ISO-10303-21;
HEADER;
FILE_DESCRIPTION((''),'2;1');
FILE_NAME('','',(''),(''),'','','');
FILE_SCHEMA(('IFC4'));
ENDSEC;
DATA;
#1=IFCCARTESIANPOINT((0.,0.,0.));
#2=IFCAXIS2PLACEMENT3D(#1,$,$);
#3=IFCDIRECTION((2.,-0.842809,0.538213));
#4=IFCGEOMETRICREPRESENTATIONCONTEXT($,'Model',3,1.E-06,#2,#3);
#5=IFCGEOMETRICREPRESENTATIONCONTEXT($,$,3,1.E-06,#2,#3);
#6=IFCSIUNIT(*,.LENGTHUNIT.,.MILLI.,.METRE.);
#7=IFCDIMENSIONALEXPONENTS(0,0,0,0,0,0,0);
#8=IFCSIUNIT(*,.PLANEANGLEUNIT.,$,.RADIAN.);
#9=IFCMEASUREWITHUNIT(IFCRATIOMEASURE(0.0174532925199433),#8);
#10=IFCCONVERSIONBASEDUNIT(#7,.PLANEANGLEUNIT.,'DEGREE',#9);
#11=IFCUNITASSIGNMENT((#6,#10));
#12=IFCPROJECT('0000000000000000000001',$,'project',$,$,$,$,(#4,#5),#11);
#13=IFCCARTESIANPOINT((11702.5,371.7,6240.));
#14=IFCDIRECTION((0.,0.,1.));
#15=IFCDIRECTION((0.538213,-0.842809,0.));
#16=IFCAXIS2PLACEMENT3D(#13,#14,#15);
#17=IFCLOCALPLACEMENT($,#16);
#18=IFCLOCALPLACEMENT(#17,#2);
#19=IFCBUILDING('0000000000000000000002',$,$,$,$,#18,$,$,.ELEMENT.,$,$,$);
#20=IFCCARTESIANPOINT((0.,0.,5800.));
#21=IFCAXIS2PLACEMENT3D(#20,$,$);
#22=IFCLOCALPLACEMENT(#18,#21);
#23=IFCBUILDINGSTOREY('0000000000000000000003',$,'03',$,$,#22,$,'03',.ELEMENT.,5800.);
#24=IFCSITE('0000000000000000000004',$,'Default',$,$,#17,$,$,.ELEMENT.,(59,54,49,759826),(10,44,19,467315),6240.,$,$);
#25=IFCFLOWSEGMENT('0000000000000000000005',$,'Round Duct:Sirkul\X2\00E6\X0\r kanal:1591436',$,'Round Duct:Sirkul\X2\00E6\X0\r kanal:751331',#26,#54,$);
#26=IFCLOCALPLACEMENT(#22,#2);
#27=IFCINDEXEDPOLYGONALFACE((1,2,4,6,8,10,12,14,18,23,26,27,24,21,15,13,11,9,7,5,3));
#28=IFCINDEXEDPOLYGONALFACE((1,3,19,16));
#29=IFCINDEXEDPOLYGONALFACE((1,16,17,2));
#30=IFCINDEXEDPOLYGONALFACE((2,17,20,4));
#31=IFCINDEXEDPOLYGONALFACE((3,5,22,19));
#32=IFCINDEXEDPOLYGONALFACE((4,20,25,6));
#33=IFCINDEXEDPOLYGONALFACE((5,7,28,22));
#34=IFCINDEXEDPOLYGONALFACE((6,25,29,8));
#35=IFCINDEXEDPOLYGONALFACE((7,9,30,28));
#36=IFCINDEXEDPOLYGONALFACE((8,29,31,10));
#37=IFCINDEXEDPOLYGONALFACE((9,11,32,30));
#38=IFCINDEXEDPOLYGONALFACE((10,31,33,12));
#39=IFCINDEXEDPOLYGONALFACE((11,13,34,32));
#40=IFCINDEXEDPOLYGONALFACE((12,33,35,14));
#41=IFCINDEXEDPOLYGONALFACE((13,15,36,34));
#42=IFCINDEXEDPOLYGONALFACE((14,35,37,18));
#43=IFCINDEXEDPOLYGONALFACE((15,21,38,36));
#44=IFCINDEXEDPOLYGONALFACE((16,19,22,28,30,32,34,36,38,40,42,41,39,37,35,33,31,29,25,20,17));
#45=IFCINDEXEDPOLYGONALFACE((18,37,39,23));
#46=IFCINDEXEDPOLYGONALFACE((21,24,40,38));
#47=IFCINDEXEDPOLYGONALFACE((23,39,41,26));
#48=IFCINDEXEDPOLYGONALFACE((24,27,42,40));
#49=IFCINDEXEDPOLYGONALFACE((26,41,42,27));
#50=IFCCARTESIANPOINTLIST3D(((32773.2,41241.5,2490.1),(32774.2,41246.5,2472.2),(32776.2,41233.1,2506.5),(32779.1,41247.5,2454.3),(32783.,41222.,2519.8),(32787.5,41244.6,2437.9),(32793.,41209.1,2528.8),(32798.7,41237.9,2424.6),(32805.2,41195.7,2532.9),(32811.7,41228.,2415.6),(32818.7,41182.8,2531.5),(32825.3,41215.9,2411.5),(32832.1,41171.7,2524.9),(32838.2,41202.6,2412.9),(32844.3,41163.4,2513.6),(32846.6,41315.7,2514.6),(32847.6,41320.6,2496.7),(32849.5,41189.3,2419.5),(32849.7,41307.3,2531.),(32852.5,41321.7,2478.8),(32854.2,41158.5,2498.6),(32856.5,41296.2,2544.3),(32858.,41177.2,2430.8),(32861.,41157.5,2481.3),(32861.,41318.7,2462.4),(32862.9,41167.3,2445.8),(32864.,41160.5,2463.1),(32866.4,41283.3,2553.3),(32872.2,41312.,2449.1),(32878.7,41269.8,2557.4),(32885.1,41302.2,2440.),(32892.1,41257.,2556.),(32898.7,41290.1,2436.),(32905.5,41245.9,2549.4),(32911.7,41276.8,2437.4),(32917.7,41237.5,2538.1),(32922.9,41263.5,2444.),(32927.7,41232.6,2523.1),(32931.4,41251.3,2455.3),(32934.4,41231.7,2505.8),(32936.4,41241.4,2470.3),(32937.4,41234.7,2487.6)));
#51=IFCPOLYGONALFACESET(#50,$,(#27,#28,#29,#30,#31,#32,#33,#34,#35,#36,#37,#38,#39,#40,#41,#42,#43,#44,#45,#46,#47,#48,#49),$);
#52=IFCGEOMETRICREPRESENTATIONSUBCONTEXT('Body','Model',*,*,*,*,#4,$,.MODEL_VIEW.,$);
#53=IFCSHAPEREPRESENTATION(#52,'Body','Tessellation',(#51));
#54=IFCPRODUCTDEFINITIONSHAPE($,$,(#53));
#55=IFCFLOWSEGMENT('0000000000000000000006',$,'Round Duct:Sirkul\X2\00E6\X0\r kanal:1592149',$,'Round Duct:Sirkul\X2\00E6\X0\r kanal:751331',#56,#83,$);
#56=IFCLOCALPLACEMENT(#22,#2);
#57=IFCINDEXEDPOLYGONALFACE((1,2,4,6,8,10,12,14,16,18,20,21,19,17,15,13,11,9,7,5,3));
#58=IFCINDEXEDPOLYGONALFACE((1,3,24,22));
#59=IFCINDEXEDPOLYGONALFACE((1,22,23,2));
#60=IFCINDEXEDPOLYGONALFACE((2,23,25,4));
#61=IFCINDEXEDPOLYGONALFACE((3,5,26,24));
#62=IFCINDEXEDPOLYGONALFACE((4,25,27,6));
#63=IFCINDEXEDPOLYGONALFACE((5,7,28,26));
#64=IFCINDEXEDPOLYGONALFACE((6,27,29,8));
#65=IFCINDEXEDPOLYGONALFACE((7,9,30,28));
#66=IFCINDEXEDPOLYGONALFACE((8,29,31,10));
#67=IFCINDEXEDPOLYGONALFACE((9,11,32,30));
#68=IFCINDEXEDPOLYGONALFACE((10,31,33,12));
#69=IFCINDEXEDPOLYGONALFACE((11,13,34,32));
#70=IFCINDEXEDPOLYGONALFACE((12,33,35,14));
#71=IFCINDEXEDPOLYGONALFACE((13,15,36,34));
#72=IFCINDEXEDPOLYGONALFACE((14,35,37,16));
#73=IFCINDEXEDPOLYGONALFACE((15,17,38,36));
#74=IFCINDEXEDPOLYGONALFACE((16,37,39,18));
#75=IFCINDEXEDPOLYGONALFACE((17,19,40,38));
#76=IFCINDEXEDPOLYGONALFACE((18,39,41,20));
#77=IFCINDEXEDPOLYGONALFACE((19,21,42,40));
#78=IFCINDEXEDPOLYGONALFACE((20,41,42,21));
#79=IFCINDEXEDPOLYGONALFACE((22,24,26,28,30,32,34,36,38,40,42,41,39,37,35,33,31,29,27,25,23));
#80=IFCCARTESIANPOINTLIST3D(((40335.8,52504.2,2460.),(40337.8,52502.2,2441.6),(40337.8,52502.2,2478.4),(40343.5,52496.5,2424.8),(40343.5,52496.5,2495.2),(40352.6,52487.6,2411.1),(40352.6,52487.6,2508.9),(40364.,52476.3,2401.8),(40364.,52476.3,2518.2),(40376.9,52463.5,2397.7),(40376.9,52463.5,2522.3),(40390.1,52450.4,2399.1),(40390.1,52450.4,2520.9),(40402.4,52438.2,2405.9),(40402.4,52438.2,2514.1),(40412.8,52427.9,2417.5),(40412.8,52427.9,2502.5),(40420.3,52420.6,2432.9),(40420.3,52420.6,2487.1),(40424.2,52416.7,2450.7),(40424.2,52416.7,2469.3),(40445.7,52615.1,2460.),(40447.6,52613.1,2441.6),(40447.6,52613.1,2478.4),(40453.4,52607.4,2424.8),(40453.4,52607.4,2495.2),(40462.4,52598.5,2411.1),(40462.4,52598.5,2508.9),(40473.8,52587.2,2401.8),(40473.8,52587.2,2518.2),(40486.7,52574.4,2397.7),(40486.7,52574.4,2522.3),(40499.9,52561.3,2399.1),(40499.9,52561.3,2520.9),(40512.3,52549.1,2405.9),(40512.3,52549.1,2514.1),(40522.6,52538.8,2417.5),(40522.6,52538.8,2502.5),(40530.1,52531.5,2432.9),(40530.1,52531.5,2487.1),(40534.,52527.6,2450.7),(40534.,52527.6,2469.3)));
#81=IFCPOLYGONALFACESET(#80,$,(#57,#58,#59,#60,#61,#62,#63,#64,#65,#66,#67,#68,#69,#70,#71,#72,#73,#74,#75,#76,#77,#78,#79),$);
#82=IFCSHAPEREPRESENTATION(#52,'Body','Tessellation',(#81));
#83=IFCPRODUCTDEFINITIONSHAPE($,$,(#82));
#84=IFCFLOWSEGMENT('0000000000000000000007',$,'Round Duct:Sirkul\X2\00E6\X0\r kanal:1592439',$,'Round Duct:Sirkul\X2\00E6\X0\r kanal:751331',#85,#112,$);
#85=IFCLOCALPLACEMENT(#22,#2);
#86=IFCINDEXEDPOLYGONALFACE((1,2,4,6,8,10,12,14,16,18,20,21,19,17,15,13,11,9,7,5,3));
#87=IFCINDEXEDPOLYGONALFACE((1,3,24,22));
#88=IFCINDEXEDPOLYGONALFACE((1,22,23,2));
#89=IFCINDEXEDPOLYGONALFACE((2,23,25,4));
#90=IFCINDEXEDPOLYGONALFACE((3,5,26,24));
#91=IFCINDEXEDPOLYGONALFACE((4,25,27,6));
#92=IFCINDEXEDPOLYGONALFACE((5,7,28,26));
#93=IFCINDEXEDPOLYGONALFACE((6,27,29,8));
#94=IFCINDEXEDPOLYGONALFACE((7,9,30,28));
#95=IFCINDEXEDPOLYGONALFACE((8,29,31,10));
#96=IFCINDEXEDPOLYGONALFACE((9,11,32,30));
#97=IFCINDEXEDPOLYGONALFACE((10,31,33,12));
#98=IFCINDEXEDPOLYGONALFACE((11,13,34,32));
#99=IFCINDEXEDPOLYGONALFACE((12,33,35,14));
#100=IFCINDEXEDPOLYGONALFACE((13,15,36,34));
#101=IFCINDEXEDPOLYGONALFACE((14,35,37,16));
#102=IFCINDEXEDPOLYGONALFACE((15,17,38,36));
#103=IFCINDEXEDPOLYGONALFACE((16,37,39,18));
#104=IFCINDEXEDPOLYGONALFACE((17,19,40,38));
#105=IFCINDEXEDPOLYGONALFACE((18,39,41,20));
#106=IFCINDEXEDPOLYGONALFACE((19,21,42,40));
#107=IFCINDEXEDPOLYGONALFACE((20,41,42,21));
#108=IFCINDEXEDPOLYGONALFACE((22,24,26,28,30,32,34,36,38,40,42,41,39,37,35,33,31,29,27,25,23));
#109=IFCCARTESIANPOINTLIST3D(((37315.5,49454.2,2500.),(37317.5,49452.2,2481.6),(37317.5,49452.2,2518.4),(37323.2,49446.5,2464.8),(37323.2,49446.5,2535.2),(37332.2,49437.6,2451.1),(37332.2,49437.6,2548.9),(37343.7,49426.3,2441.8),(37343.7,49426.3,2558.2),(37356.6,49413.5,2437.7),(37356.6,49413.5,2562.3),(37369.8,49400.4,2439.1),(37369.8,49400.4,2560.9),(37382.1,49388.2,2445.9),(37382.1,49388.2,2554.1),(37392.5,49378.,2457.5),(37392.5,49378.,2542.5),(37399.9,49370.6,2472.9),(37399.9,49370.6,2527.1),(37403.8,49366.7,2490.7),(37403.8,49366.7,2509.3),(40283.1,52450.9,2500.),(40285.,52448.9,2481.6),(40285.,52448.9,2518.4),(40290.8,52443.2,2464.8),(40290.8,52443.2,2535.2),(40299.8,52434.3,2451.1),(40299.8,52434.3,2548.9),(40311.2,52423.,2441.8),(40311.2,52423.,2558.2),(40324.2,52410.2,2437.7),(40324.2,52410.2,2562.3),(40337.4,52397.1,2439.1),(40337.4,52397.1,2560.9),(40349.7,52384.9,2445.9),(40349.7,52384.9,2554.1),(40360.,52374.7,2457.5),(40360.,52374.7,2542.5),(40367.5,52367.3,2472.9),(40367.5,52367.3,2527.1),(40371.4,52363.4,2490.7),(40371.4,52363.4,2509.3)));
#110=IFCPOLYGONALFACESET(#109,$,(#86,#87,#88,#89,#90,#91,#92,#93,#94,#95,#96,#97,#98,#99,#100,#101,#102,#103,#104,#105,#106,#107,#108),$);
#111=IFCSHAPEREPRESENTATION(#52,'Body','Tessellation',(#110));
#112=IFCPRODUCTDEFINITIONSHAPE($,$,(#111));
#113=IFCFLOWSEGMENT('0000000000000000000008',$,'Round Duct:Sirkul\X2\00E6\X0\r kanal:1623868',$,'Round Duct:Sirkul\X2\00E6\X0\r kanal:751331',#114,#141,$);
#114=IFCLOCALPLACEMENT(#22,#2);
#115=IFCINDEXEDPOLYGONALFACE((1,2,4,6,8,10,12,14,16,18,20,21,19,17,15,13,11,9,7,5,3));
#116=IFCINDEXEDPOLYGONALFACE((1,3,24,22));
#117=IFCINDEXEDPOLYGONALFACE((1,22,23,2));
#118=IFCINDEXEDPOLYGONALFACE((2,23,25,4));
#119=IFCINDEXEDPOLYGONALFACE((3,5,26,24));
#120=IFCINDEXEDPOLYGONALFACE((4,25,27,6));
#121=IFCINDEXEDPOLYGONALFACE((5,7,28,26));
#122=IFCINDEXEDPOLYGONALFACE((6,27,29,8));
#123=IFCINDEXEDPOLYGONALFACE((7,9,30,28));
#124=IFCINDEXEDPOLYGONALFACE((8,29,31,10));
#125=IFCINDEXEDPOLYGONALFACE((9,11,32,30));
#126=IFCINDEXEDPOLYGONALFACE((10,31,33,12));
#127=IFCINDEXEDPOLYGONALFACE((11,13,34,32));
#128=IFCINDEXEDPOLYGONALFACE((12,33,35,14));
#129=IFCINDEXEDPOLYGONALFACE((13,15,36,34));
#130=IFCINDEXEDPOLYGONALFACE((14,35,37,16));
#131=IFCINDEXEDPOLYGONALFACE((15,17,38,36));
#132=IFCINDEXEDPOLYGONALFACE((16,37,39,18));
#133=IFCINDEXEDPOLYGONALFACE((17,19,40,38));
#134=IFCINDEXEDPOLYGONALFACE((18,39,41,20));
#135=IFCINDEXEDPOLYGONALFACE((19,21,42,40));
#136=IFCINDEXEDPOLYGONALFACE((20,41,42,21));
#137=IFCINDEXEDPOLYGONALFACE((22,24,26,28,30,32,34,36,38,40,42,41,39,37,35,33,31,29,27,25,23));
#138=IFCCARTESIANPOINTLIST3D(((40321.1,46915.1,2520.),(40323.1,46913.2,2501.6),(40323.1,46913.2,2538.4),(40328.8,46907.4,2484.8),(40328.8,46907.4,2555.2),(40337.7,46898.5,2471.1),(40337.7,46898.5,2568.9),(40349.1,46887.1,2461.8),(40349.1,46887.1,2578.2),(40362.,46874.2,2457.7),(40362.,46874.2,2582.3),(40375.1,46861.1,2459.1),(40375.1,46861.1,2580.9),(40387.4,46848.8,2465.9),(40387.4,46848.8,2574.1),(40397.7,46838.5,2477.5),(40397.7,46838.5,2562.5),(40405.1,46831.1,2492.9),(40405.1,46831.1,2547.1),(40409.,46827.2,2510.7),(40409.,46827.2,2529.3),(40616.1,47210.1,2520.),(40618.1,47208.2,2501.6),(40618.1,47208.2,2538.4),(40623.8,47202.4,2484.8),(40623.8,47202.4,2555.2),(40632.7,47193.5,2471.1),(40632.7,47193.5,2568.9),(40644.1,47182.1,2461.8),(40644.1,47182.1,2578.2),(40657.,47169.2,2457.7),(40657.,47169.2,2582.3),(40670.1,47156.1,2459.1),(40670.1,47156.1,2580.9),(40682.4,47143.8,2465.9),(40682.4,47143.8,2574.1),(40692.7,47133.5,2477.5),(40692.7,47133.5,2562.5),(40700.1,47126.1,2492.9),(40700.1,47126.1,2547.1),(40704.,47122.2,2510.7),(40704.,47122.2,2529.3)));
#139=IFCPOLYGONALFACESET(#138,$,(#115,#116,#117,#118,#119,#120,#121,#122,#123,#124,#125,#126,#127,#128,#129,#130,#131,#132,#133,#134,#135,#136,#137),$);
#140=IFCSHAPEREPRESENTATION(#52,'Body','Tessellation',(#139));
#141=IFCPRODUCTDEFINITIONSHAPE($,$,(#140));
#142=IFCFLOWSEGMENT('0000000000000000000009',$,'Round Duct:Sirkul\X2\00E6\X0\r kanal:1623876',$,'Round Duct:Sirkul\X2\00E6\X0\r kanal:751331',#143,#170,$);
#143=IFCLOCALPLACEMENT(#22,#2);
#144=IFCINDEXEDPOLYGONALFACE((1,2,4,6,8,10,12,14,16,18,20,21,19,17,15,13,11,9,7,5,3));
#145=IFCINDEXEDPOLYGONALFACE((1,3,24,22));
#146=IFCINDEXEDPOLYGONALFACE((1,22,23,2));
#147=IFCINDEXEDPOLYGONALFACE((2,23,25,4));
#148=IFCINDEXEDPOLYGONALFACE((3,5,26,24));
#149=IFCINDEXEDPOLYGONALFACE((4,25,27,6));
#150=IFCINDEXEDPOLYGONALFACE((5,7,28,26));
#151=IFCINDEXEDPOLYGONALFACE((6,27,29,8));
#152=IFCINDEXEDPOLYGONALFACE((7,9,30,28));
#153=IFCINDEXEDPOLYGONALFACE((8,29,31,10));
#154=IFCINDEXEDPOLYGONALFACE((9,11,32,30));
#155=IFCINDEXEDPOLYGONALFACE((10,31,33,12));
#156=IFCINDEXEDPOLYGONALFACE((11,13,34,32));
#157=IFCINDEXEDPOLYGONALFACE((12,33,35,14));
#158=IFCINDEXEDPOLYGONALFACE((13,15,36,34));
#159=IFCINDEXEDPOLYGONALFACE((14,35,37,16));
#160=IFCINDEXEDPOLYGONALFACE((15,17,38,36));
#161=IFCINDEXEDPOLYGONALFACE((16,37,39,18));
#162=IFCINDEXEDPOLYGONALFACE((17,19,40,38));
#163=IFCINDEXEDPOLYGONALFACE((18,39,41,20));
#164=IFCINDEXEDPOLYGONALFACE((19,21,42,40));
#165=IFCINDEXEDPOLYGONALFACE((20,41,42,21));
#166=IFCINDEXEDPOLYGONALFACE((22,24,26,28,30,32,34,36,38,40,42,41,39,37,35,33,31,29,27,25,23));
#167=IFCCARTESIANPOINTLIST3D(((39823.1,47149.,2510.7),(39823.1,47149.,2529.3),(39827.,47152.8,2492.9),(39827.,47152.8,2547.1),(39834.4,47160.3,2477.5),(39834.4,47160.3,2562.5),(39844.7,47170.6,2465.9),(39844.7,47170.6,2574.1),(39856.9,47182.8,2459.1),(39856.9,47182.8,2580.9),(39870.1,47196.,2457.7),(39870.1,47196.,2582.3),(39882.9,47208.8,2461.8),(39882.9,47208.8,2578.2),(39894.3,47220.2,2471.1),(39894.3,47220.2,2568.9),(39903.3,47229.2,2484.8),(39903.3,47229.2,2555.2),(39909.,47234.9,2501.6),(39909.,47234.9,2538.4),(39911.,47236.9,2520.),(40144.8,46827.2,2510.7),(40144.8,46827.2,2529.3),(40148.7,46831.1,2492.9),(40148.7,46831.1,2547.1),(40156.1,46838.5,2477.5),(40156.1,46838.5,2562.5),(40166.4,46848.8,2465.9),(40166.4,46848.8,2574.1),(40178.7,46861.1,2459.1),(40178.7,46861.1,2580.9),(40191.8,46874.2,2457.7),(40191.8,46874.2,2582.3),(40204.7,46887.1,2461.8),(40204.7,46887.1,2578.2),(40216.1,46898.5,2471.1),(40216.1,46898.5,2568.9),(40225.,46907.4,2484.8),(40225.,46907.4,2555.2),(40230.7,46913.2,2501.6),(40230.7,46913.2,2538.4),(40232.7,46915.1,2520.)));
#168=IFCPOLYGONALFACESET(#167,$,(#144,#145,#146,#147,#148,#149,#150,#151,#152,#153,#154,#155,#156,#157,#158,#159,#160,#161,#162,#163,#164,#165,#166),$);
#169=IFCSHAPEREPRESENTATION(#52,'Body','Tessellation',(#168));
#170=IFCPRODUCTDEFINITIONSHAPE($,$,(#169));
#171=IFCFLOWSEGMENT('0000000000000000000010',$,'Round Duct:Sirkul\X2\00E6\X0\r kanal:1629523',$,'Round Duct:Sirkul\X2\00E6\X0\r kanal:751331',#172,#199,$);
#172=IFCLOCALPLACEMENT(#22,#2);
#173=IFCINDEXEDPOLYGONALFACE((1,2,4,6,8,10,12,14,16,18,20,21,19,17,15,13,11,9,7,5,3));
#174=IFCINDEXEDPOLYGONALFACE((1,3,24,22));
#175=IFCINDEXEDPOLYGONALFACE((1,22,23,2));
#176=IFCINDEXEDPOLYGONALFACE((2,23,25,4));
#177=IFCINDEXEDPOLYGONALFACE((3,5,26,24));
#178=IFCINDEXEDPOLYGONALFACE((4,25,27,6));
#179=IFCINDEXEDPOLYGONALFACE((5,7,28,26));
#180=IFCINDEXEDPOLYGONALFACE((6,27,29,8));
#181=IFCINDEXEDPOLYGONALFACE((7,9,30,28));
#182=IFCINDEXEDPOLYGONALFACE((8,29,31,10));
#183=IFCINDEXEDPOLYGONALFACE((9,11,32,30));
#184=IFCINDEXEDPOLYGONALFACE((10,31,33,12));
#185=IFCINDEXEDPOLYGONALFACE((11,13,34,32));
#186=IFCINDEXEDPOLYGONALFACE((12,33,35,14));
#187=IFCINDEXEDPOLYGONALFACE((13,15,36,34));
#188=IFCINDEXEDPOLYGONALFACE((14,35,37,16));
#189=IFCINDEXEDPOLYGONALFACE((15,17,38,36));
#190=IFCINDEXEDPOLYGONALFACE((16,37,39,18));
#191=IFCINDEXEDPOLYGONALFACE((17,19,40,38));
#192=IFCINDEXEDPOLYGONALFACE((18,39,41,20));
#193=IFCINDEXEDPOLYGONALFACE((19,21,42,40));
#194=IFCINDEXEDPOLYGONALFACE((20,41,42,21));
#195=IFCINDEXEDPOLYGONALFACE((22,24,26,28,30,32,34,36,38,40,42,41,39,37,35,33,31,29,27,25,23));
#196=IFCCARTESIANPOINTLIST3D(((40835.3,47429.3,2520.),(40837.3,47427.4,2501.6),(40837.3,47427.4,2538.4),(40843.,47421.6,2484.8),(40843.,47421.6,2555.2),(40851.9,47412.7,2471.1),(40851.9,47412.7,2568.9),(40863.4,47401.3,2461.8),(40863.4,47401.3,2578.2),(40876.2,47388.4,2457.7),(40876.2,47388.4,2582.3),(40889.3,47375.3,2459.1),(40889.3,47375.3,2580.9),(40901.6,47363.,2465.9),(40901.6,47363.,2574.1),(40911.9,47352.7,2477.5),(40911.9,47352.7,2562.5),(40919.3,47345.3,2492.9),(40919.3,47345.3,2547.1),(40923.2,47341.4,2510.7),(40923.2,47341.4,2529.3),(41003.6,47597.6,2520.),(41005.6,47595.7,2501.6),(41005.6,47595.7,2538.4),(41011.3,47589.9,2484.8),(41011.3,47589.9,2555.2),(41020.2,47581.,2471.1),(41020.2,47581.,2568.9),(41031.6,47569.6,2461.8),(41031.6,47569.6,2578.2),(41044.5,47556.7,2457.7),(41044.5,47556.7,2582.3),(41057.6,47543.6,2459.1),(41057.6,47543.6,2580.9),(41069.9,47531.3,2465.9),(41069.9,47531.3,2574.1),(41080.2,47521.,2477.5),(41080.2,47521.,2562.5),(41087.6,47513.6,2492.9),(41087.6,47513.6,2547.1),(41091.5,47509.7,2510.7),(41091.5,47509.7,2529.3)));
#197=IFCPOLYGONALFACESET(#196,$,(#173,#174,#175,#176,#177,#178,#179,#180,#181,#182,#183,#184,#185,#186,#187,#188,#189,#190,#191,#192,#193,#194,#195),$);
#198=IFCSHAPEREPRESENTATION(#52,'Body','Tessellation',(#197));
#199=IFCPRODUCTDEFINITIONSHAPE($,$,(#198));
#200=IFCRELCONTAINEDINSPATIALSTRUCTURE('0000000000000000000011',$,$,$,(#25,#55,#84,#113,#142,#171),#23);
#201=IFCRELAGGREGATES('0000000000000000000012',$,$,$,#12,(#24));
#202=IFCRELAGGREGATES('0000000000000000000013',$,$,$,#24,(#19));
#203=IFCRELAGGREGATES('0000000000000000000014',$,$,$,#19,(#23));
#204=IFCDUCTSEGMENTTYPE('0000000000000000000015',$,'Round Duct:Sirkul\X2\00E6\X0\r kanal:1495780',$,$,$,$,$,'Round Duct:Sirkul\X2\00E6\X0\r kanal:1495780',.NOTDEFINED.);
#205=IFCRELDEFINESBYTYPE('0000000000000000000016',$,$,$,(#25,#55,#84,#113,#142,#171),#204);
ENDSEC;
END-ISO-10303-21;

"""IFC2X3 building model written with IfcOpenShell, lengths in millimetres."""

from ifc_helpers import new_model, entity, si_unit, converted_unit, direction, frame, frame_2d, origin, origin_2d_with_axis, place, context, subcontext, project, spatial, circle, extrude, type_object, element, save


model = new_model("IFC2X3")

# Units and contexts
model_context = context("Model", 3, precision=1e-06, world=origin(), true_north=direction((2.0, -0.842809, 0.538213)))
context_of_model = context(None, 3, precision=1e-06, world=origin(), true_north=direction((2.0, -0.842809, 0.538213)))
body_context = subcontext(model_context, "Body", "Model", "MODEL_VIEW")
ifc_project = project(units=[si_unit("LENGTHUNIT", "METRE", prefix="MILLI"), converted_unit("PLANEANGLEUNIT", "DEGREE", entity("IfcRatioMeasure", 0.0174532925199433), si_unit("PLANEANGLEUNIT", "RADIAN"), dimensions=[0, 0, 0, 0, 0, 0, 0])], contexts=[model_context, context_of_model])

# Site, building, storey
site_placement = place(None, frame((11702.5, 371.7, 6240.0), z_axis=(0.0, 0.0, 1.0), x_axis=(0.538213, -0.842809, 0.0)))
site = spatial("IfcSite", under=ifc_project, at=site_placement, Name="Default", CompositionType="ELEMENT", RefLatitude=(59, 54, 49, 759826), RefLongitude=(10, 44, 19, 467315), RefElevation=6240.0)
building_placement = place(site_placement, origin())
building = spatial("IfcBuilding", under=site, at=building_placement, CompositionType="ELEMENT")
storey_placement = place(building_placement, frame((0.0, 0.0, 5800.0)))
storey = spatial("IfcBuildingStorey", under=building, at=storey_placement, Name="03", LongName="03", CompositionType="ELEMENT", Elevation=5800.0)

# Flow segments
duct_segment_type = type_object("IfcDuctSegmentType", Name="Round Duct:Sirkulær kanal:1495780", ElementType="Round Duct:Sirkulær kanal:1495780", PredefinedType="NOTDEFINED")
flow_segment_1_placement = place(storey_placement, origin())
element("IfcFlowSegment", 1, at=flow_segment_1_placement, inside=storey, type_object=duct_segment_type, Name="Round Duct:Sirkulær kanal:1591436", ObjectType="Round Duct:Sirkulær kanal:751331", context=body_context, shape_type="SweptSolid", body=[
    extrude(circle(Radius=62.5, at=origin_2d_with_axis()), frame((32818.6, 41202.5, 2472.2), z_axis=(0.685047, 0.691775, 0.228382), x_axis=(-0.710554, 0.703643, 0.0)), (0.0, 0.0, 1.0), 107.2),
])
flow_segment_2_placement = place(storey_placement, origin())
element("IfcFlowSegment", 2, at=flow_segment_2_placement, inside=storey, type_object=duct_segment_type, Name="Round Duct:Sirkulær kanal:1592149", ObjectType="Round Duct:Sirkulær kanal:751331", context=body_context, shape_type="SweptSolid", body=[
    extrude(circle(Radius=62.5, at=origin_2d_with_axis()), frame((40380.2, 52460.2, 2460.0), z_axis=(0.703643, 0.710553, 0.0), x_axis=(-0.710553, 0.703643, 0.0)), (0.0, 0.0, 1.0), 156.1),
])
flow_segment_3_placement = place(storey_placement, origin())
element("IfcFlowSegment", 3, at=flow_segment_3_placement, inside=storey, type_object=duct_segment_type, Name="Round Duct:Sirkulær kanal:1592439", ObjectType="Round Duct:Sirkulær kanal:751331", context=body_context, shape_type="SweptSolid", body=[
    extrude(circle(Radius=62.5, at=origin_2d_with_axis()), frame((37359.9, 49410.2, 2500.0), z_axis=(0.703643, 0.710553, 0.0), x_axis=(-0.710553, 0.703643, 0.0)), (0.0, 0.0, 1.0), 4217.4),
])
flow_segment_4_placement = place(storey_placement, origin())
element("IfcFlowSegment", 4, at=flow_segment_4_placement, inside=storey, type_object=duct_segment_type, Name="Round Duct:Sirkulær kanal:1623868", ObjectType="Round Duct:Sirkulær kanal:751331", context=body_context, shape_type="SweptSolid", body=[
    extrude(circle(Radius=62.5, at=frame_2d((0.0, 0.0), x_axis=(1.0, 0.0))), frame((40365.3, 46870.9, 2520.0), z_axis=(0.707107, 0.707107, 0.0), x_axis=(-0.707107, 0.707107, 0.0)), (0.0, 0.0, 1.0), 417.2),
])
flow_segment_5_placement = place(storey_placement, origin())
element("IfcFlowSegment", 5, at=flow_segment_5_placement, inside=storey, type_object=duct_segment_type, Name="Round Duct:Sirkulær kanal:1623876", ObjectType="Round Duct:Sirkulær kanal:751331", context=body_context, shape_type="SweptSolid", body=[
    extrude(circle(Radius=62.5, at=frame_2d((0.0, 0.0), x_axis=(1.0, 0.0))), frame((39866.8, 47192.7, 2520.0), z_axis=(0.707107, -0.707107, 0.0), x_axis=(0.707107, 0.707107, 0.0)), (0.0, 0.0, 1.0), 455.0),
])
flow_segment_6_placement = place(storey_placement, origin())
element("IfcFlowSegment", 6, at=flow_segment_6_placement, inside=storey, type_object=duct_segment_type, Name="Round Duct:Sirkulær kanal:1629523", ObjectType="Round Duct:Sirkulær kanal:751331", context=body_context, shape_type="SweptSolid", body=[
    extrude(circle(Radius=62.5, at=frame_2d((0.0, 0.0), x_axis=(1.0, 0.0))), frame((40879.5, 47385.1, 2520.0), z_axis=(0.707107, 0.707107, 0.0), x_axis=(-0.707107, 0.707107, 0.0)), (0.0, 0.0, 1.0), 238.0),
])

save(model, "model.ifc")
